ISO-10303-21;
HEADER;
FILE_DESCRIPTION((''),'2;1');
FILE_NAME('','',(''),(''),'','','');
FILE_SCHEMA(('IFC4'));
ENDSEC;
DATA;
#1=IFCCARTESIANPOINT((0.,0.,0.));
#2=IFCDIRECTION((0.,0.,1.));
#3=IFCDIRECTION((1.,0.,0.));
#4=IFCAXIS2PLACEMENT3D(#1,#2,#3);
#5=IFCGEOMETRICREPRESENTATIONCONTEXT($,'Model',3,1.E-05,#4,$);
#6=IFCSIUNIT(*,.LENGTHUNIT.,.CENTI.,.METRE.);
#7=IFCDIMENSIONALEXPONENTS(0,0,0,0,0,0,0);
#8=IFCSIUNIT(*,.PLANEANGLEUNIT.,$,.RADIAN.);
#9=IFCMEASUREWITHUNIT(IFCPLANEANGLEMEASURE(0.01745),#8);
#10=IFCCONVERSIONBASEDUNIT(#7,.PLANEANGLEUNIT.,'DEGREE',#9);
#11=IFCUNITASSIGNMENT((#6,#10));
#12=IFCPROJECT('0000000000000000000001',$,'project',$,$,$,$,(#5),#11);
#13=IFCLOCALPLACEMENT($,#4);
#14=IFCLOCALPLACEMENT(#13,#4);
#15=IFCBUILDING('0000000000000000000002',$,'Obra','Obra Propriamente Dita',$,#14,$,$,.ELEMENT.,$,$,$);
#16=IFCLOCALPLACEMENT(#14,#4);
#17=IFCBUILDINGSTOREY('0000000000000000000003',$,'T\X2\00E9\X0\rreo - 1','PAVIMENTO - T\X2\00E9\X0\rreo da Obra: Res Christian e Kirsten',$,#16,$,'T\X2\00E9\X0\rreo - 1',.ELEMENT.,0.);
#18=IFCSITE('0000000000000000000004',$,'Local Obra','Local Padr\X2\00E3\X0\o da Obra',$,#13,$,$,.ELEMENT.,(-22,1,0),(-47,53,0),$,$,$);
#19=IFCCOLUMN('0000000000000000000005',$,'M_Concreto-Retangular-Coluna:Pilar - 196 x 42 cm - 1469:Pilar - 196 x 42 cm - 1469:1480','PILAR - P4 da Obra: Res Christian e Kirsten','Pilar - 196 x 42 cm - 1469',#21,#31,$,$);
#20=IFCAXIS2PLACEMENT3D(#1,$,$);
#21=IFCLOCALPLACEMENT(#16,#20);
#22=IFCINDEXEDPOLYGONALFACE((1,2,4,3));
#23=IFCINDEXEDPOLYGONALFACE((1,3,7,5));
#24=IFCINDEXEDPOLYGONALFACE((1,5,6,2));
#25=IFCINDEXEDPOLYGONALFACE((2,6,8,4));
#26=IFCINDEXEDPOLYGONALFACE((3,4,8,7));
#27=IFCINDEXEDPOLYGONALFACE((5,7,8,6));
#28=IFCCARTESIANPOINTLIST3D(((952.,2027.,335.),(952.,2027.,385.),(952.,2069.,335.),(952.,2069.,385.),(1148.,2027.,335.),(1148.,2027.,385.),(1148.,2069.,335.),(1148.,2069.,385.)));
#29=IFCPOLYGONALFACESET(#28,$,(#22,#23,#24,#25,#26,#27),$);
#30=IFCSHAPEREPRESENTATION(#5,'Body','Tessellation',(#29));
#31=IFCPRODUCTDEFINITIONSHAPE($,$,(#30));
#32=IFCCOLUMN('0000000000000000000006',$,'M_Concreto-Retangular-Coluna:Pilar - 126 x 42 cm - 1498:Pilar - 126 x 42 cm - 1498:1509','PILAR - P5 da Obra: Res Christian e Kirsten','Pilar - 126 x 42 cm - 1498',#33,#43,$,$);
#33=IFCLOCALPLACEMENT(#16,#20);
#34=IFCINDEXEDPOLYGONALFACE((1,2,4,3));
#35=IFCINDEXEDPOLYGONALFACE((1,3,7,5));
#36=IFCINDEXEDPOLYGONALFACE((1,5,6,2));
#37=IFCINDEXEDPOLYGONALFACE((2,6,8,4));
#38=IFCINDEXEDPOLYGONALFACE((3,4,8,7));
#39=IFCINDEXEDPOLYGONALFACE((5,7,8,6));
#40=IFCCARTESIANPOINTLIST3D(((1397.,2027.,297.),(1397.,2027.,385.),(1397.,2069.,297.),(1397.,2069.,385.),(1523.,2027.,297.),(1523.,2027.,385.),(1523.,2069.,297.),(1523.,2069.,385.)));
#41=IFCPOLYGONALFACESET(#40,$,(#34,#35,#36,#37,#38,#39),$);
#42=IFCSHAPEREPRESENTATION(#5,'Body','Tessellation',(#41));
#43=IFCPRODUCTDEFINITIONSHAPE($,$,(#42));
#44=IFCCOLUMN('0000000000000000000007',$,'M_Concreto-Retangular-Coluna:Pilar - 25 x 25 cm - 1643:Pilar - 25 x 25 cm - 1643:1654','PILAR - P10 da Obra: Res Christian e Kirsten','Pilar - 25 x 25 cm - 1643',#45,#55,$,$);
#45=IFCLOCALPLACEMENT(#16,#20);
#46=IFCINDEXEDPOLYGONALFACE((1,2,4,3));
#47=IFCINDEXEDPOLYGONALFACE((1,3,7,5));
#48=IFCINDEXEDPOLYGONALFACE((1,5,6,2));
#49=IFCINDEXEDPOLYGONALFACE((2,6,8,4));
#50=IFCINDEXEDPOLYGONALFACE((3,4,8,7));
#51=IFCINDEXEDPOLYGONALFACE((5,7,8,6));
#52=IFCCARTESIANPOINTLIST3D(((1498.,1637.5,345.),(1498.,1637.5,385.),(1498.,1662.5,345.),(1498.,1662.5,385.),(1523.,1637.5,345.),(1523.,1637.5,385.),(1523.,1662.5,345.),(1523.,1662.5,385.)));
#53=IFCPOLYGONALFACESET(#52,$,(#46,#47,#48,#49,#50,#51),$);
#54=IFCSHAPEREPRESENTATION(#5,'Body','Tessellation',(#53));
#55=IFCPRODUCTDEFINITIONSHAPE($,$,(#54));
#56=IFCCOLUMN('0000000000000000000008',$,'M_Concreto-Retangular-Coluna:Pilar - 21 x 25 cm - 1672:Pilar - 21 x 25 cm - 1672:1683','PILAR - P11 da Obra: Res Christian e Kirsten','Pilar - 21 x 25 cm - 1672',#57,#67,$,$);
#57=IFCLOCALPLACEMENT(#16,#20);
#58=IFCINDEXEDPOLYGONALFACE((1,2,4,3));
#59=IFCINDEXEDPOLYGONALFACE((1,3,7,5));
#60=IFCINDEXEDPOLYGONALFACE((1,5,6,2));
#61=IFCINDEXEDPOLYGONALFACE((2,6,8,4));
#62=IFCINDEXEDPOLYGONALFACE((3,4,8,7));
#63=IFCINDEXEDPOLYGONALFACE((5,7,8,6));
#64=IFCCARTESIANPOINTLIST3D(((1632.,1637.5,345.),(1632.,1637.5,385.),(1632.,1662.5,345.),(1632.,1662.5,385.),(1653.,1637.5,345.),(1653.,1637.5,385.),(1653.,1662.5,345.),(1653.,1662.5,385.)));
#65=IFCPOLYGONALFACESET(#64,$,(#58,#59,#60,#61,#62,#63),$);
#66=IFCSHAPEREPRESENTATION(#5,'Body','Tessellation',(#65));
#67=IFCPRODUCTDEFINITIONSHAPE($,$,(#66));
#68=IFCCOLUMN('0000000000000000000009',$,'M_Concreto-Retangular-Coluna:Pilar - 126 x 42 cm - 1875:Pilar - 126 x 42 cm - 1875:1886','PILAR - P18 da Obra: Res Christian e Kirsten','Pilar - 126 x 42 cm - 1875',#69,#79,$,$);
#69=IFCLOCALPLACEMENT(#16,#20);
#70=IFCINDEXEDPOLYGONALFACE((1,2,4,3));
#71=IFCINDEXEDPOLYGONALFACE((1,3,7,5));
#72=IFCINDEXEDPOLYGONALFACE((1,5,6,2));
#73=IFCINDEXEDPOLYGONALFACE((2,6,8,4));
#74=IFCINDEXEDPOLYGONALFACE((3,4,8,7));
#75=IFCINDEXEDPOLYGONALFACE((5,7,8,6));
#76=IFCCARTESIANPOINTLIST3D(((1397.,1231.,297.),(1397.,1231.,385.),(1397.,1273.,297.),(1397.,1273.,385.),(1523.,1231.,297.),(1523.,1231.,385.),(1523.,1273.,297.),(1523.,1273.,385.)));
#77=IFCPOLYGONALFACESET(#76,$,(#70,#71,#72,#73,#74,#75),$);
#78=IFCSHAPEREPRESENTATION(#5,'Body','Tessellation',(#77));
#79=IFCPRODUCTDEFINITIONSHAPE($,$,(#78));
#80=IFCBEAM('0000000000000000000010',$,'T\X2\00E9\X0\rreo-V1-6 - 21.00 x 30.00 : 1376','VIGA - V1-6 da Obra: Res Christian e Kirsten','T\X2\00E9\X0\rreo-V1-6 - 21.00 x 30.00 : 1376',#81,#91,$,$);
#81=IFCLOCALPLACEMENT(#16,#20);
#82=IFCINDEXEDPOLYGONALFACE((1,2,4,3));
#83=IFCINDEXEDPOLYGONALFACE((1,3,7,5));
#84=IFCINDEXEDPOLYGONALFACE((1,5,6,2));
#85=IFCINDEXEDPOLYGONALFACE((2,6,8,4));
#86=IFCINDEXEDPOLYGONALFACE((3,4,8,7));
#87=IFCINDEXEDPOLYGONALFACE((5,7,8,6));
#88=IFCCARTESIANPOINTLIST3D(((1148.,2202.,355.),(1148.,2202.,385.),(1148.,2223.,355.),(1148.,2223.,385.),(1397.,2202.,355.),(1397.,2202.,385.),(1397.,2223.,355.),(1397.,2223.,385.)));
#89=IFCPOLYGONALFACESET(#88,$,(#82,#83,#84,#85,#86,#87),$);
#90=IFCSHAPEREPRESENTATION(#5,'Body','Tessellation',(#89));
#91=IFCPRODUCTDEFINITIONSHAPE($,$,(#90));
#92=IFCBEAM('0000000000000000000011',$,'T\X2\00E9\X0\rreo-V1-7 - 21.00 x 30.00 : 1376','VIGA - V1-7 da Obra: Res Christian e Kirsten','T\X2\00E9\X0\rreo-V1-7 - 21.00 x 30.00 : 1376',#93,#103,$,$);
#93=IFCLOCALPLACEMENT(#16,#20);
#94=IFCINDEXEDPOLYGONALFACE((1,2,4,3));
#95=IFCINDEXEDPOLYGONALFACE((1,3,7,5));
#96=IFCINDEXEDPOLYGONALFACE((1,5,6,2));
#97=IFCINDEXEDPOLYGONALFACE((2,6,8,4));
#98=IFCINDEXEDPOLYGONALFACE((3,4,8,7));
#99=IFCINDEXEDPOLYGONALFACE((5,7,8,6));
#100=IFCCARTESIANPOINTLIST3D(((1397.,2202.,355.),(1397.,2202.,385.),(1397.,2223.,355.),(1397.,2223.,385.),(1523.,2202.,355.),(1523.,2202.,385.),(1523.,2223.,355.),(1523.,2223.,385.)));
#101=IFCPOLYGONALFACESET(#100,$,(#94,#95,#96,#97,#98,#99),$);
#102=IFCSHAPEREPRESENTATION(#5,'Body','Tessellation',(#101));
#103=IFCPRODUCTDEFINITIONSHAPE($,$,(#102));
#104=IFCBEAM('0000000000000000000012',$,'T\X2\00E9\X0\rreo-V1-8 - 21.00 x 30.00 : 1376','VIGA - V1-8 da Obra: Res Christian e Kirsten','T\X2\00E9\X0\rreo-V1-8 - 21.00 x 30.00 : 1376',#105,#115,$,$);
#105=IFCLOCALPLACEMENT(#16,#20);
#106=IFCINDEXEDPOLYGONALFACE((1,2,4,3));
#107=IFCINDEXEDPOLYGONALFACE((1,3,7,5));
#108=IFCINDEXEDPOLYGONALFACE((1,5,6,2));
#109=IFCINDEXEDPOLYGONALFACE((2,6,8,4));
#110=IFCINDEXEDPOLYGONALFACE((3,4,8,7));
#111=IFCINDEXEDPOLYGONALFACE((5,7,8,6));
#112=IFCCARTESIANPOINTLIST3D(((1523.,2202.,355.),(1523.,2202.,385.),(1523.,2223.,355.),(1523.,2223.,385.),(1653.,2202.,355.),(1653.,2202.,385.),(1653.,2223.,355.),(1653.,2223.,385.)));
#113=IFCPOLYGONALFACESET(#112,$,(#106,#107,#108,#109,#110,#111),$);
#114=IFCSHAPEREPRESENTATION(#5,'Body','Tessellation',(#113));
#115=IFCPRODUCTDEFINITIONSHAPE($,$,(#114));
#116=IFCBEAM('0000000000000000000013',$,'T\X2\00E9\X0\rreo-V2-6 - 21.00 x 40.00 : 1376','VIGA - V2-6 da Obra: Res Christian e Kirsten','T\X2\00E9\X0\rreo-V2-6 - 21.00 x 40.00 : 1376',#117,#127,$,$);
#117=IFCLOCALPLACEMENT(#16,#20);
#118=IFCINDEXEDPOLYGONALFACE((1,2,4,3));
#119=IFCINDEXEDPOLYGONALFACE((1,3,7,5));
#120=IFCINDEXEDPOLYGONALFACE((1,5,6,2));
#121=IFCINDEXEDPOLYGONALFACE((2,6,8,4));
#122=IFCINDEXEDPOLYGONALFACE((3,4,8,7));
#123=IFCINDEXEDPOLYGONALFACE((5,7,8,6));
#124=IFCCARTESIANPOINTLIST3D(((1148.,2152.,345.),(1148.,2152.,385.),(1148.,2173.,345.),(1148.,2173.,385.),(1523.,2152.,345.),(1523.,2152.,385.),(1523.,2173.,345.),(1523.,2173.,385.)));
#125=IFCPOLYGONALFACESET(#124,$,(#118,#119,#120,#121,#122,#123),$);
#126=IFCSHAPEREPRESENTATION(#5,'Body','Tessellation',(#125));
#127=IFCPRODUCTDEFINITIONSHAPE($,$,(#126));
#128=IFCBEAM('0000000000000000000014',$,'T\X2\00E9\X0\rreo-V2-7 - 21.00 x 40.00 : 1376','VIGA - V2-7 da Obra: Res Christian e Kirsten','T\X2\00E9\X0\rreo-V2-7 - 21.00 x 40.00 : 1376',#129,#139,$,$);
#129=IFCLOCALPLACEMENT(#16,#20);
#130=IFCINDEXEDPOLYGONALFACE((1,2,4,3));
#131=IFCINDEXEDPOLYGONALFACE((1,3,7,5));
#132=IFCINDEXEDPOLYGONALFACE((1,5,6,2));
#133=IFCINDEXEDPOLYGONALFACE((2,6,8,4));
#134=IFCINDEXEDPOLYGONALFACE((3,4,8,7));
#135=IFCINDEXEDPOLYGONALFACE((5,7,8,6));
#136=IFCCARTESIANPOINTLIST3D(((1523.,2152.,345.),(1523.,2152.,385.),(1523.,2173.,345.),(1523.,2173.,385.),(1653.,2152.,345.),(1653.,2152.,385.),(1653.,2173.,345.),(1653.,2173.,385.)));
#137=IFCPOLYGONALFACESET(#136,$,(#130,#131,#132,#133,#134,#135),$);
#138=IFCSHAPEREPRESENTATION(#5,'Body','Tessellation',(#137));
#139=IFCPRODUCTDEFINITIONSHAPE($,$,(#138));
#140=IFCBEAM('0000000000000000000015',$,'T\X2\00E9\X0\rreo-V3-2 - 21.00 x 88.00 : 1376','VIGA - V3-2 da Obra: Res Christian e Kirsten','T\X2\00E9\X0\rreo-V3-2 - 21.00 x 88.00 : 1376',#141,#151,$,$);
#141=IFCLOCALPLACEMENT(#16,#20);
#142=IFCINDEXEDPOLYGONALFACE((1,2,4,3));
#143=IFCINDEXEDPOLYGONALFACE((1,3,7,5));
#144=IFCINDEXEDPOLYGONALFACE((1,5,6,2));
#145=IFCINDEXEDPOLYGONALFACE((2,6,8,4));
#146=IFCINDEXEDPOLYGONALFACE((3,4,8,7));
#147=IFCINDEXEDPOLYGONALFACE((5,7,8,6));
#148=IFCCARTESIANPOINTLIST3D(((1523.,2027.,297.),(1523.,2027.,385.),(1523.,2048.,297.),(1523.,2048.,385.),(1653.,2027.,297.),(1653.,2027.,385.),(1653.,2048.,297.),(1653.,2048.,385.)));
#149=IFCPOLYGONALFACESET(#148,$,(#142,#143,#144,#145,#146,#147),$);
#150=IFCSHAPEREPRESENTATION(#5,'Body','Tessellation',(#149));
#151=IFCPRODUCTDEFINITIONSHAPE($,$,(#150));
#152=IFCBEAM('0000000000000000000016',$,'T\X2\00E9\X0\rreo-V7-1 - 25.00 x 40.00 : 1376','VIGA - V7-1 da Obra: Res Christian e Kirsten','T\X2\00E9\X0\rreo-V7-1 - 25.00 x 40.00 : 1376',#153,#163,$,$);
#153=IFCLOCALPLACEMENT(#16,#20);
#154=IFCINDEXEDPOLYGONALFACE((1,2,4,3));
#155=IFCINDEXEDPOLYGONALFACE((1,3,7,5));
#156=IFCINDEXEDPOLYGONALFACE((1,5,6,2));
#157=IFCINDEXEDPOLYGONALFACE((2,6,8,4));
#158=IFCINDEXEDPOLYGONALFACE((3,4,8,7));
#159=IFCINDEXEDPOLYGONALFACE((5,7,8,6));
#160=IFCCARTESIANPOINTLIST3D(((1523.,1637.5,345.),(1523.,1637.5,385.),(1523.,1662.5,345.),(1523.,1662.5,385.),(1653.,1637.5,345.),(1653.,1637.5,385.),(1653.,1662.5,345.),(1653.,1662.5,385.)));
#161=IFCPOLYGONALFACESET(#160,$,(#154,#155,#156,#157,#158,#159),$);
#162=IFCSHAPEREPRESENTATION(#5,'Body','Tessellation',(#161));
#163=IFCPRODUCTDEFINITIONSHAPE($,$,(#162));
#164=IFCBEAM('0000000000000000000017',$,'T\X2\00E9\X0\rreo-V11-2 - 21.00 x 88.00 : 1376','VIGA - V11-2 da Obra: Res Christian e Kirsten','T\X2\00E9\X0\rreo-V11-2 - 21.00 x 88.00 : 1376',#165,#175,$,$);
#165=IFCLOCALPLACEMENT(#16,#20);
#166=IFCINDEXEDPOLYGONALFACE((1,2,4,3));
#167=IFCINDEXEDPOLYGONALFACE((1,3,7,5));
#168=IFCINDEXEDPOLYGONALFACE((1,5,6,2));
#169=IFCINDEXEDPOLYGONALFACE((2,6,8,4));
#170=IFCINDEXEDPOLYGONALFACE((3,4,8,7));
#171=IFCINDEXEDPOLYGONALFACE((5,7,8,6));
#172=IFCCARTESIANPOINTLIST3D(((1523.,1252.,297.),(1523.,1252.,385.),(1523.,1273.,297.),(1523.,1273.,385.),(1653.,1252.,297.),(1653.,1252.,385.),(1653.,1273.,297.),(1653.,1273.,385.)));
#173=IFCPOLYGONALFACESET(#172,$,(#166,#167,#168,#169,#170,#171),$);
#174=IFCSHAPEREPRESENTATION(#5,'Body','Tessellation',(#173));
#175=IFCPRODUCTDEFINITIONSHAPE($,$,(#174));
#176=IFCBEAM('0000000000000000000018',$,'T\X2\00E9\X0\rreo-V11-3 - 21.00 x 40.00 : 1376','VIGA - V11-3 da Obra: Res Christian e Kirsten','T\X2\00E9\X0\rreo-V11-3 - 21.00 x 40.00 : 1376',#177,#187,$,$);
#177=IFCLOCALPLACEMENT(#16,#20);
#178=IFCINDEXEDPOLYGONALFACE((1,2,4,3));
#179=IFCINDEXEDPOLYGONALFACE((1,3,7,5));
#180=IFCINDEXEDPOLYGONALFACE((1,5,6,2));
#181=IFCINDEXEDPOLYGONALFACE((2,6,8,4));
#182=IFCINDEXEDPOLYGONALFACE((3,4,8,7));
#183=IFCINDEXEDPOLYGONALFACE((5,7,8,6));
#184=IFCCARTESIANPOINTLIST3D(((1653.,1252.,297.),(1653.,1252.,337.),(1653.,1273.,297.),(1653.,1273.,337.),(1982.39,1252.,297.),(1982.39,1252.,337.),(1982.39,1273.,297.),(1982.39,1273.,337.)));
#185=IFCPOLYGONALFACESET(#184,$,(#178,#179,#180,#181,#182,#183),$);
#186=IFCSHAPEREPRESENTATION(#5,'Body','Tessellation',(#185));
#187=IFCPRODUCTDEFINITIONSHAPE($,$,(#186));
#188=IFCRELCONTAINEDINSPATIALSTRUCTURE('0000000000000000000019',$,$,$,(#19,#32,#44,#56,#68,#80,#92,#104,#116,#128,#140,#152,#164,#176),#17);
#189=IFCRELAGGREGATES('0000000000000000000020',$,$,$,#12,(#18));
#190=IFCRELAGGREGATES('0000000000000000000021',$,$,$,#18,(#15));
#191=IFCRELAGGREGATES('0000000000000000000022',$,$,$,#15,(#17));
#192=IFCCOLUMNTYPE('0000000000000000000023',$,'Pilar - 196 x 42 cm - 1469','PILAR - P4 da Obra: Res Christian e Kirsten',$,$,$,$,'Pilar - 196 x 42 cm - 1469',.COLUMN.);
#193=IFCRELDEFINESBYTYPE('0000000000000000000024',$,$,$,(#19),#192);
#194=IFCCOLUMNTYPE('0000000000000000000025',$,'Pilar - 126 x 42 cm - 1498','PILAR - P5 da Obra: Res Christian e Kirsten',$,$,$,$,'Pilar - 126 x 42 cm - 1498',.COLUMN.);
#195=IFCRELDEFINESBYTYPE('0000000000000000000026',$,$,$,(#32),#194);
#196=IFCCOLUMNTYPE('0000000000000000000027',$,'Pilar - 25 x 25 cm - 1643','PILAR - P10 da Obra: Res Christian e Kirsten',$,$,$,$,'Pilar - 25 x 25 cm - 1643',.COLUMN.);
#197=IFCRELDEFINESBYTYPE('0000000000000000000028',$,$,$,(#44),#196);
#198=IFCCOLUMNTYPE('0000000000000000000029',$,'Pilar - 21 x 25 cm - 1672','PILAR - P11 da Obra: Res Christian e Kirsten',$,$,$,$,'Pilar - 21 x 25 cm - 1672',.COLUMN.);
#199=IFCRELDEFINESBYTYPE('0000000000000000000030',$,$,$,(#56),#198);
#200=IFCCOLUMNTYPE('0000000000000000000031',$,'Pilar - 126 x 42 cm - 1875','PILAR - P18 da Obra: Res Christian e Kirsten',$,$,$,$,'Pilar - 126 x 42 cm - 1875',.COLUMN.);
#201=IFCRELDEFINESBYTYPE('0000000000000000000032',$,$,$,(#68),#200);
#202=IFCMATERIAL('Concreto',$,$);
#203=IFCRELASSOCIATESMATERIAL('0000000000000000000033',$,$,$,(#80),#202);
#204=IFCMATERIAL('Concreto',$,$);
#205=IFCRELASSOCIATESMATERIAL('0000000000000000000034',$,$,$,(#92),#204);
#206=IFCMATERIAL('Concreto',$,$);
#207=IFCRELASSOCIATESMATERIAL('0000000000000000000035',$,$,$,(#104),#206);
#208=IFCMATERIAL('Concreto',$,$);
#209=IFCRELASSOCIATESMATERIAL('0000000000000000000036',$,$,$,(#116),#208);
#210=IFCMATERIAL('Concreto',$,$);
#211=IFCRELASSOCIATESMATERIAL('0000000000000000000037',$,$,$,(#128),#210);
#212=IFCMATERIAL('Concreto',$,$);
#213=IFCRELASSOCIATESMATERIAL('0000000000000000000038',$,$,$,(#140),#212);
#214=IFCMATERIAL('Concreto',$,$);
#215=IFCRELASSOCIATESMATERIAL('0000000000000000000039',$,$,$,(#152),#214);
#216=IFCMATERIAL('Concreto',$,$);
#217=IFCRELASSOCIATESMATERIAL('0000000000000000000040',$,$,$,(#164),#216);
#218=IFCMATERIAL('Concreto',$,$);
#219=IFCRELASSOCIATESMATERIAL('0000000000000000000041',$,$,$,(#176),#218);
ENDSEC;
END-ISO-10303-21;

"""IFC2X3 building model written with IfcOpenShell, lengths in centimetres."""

from ifc_helpers import new_model, entity, si_unit, converted_unit, frame, origin, origin_with_axes, origin_2d_with_axis, place, context, project, spatial, polyline, rectangle, outline, extrude, source, transform, mapped, material, type_object, type_shapes, element, save


model = new_model("IFC2X3")

# Units and contexts
model_context = context("Model", 3, precision=1e-05, world=origin_with_axes())
ifc_project = project(units=[si_unit("LENGTHUNIT", "METRE", prefix="CENTI"), converted_unit("PLANEANGLEUNIT", "DEGREE", entity("IfcPlaneAngleMeasure", 0.01745), si_unit("PLANEANGLEUNIT", "RADIAN"), dimensions=[0, 0, 0, 0, 0, 0, 0])], contexts=[model_context])

# Site, building, storey
site_placement = place(None, origin_with_axes())
site = spatial("IfcSite", under=ifc_project, at=site_placement, Name="Local Obra", Description="Local Padrão da Obra", CompositionType="ELEMENT", RefLatitude=(-22, 1, 0), RefLongitude=(-47, 53, 0))
building_placement = place(site_placement, origin_with_axes())
building = spatial("IfcBuilding", under=site, at=building_placement, Name="Obra", Description="Obra Propriamente Dita", CompositionType="ELEMENT")
storey_placement = place(building_placement, origin_with_axes())
storey = spatial("IfcBuildingStorey", under=building, at=storey_placement, Name="Térreo - 1", Description="PAVIMENTO - Térreo da Obra: Res Christian e Kirsten", LongName="Térreo - 1", CompositionType="ELEMENT", Elevation=0.0)

# Columns
column_type_1 = type_object("IfcColumnType", Name="Pilar - 196 x 42 cm - 1469", Description="PILAR - P4 da Obra: Res Christian e Kirsten", ElementType="Pilar - 196 x 42 cm - 1469", PredefinedType="COLUMN")
shared_shape_1 = source(origin(), model_context, "Body", "SweptSolid", [
    extrude(rectangle(XDim=196.0, YDim=42.0, at=origin_2d_with_axis()), origin(), (0.0, 0.0, 1.0), 50.0),
])
type_shapes(column_type_1, [shared_shape_1])
column_1_placement = place(storey_placement, frame((1050.0, 2048.0, 335.0), z_axis=(0.0, 0.0, 1.0), x_axis=(1.0, 0.0, 0.0)))
element("IfcColumn", 1, at=column_1_placement, inside=storey, type_object=column_type_1, Name="M_Concreto-Retangular-Coluna:Pilar - 196 x 42 cm - 1469:Pilar - 196 x 42 cm - 1469:1480", Description="PILAR - P4 da Obra: Res Christian e Kirsten", ObjectType="Pilar - 196 x 42 cm - 1469", context=model_context, shape_type="MappedRepresentation", body=[
    mapped(shared_shape_1, transform((0.0, 0.0, 0.0), scale=1.0)),
])
column_type_2 = type_object("IfcColumnType", Name="Pilar - 126 x 42 cm - 1498", Description="PILAR - P5 da Obra: Res Christian e Kirsten", ElementType="Pilar - 126 x 42 cm - 1498", PredefinedType="COLUMN")
shared_shape_2 = source(origin(), model_context, "Body", "SweptSolid", [
    extrude(rectangle(XDim=126.0, YDim=42.0, at=origin_2d_with_axis()), origin(), (0.0, 0.0, 1.0), 88.0),
])
type_shapes(column_type_2, [shared_shape_2])
column_2_placement = place(storey_placement, frame((1460.0, 2048.0, 297.0), z_axis=(0.0, 0.0, 1.0), x_axis=(1.0, 0.0, 0.0)))
element("IfcColumn", 2, at=column_2_placement, inside=storey, type_object=column_type_2, Name="M_Concreto-Retangular-Coluna:Pilar - 126 x 42 cm - 1498:Pilar - 126 x 42 cm - 1498:1509", Description="PILAR - P5 da Obra: Res Christian e Kirsten", ObjectType="Pilar - 126 x 42 cm - 1498", context=model_context, shape_type="MappedRepresentation", body=[
    mapped(shared_shape_2, transform((0.0, 0.0, 0.0), scale=1.0)),
])
column_type_3 = type_object("IfcColumnType", Name="Pilar - 25 x 25 cm - 1643", Description="PILAR - P10 da Obra: Res Christian e Kirsten", ElementType="Pilar - 25 x 25 cm - 1643", PredefinedType="COLUMN")
shared_shape_3 = source(origin(), model_context, "Body", "SweptSolid", [
    extrude(rectangle(XDim=25.0, YDim=25.0, at=origin_2d_with_axis()), origin(), (0.0, 0.0, 1.0), 40.0),
])
type_shapes(column_type_3, [shared_shape_3])
column_3_placement = place(storey_placement, frame((1510.5, 1650.0, 345.0), z_axis=(0.0, 0.0, 1.0), x_axis=(1.0, 0.0, 0.0)))
element("IfcColumn", 3, at=column_3_placement, inside=storey, type_object=column_type_3, Name="M_Concreto-Retangular-Coluna:Pilar - 25 x 25 cm - 1643:Pilar - 25 x 25 cm - 1643:1654", Description="PILAR - P10 da Obra: Res Christian e Kirsten", ObjectType="Pilar - 25 x 25 cm - 1643", context=model_context, shape_type="MappedRepresentation", body=[
    mapped(shared_shape_3, transform((0.0, 0.0, 0.0), scale=1.0)),
])
column_type_4 = type_object("IfcColumnType", Name="Pilar - 21 x 25 cm - 1672", Description="PILAR - P11 da Obra: Res Christian e Kirsten", ElementType="Pilar - 21 x 25 cm - 1672", PredefinedType="COLUMN")
shared_shape_4 = source(origin(), model_context, "Body", "SweptSolid", [
    extrude(rectangle(XDim=21.0, YDim=25.0, at=origin_2d_with_axis()), origin(), (0.0, 0.0, 1.0), 40.0),
])
type_shapes(column_type_4, [shared_shape_4])
column_4_placement = place(storey_placement, frame((1642.5, 1650.0, 345.0), z_axis=(0.0, 0.0, 1.0), x_axis=(1.0, 0.0, 0.0)))
element("IfcColumn", 4, at=column_4_placement, inside=storey, type_object=column_type_4, Name="M_Concreto-Retangular-Coluna:Pilar - 21 x 25 cm - 1672:Pilar - 21 x 25 cm - 1672:1683", Description="PILAR - P11 da Obra: Res Christian e Kirsten", ObjectType="Pilar - 21 x 25 cm - 1672", context=model_context, shape_type="MappedRepresentation", body=[
    mapped(shared_shape_4, transform((0.0, 0.0, 0.0), scale=1.0)),
])
column_type_5 = type_object("IfcColumnType", Name="Pilar - 126 x 42 cm - 1875", Description="PILAR - P18 da Obra: Res Christian e Kirsten", ElementType="Pilar - 126 x 42 cm - 1875", PredefinedType="COLUMN")
shared_shape_5 = source(origin(), model_context, "Body", "SweptSolid", [
    extrude(rectangle(XDim=126.0, YDim=42.0, at=origin_2d_with_axis()), origin(), (0.0, 0.0, 1.0), 88.0),
])
type_shapes(column_type_5, [shared_shape_5])
column_5_placement = place(storey_placement, frame((1460.0, 1252.0, 297.0), z_axis=(0.0, 0.0, 1.0), x_axis=(1.0, 0.0, 0.0)))
element("IfcColumn", 5, at=column_5_placement, inside=storey, type_object=column_type_5, Name="M_Concreto-Retangular-Coluna:Pilar - 126 x 42 cm - 1875:Pilar - 126 x 42 cm - 1875:1886", Description="PILAR - P18 da Obra: Res Christian e Kirsten", ObjectType="Pilar - 126 x 42 cm - 1875", context=model_context, shape_type="MappedRepresentation", body=[
    mapped(shared_shape_5, transform((0.0, 0.0, 0.0), scale=1.0)),
])

# Beams
ifc_material_1 = material(Name="Concreto")
beam_1_placement = place(storey_placement, frame((1148.0, 2223.0, 385.0), z_axis=(1.0, 0.0, 0.0), x_axis=(0.0, -1.0, 0.0)))
element("IfcBeam", 6, at=beam_1_placement, inside=storey, material=ifc_material_1, Name="Térreo-V1-6 - 21.00 x 30.00 : 1376", Description="VIGA - V1-6 da Obra: Res Christian e Kirsten", ObjectType="Térreo-V1-6 - 21.00 x 30.00 : 1376", context=model_context, shape_type="SweptSolid", body=[
    extrude(outline(polyline([(0.0, 0.0), (21.0, 0.0), (21.0, 30.0), (0.0, 30.0), (0.0, 0.0)])), origin_with_axes(), (0.0, 0.0, 1.0), 249.0),
])
ifc_material_2 = material(Name="Concreto")
beam_2_placement = place(storey_placement, frame((1397.0, 2223.0, 385.0), z_axis=(1.0, 0.0, 0.0), x_axis=(0.0, -1.0, 0.0)))
element("IfcBeam", 7, at=beam_2_placement, inside=storey, material=ifc_material_2, Name="Térreo-V1-7 - 21.00 x 30.00 : 1376", Description="VIGA - V1-7 da Obra: Res Christian e Kirsten", ObjectType="Térreo-V1-7 - 21.00 x 30.00 : 1376", context=model_context, shape_type="SweptSolid", body=[
    extrude(outline(polyline([(0.0, 0.0), (21.0, 0.0), (21.0, 30.0), (0.0, 30.0), (0.0, 0.0)])), origin_with_axes(), (0.0, 0.0, 1.0), 126.0),
])
ifc_material_3 = material(Name="Concreto")
beam_3_placement = place(storey_placement, frame((1523.0, 2223.0, 385.0), z_axis=(1.0, 0.0, 0.0), x_axis=(0.0, -1.0, 0.0)))
element("IfcBeam", 8, at=beam_3_placement, inside=storey, material=ifc_material_3, Name="Térreo-V1-8 - 21.00 x 30.00 : 1376", Description="VIGA - V1-8 da Obra: Res Christian e Kirsten", ObjectType="Térreo-V1-8 - 21.00 x 30.00 : 1376", context=model_context, shape_type="SweptSolid", body=[
    extrude(outline(polyline([(0.0, 0.0), (21.0, 0.0), (21.0, 30.0), (0.0, 30.0), (0.0, 0.0)])), origin_with_axes(), (0.0, 0.0, 1.0), 130.0),
])
ifc_material_4 = material(Name="Concreto")
beam_4_placement = place(storey_placement, frame((1148.0, 2173.0, 385.0), z_axis=(1.0, 0.0, 0.0), x_axis=(0.0, -1.0, 0.0)))
element("IfcBeam", 9, at=beam_4_placement, inside=storey, material=ifc_material_4, Name="Térreo-V2-6 - 21.00 x 40.00 : 1376", Description="VIGA - V2-6 da Obra: Res Christian e Kirsten", ObjectType="Térreo-V2-6 - 21.00 x 40.00 : 1376", context=model_context, shape_type="SweptSolid", body=[
    extrude(outline(polyline([(0.0, 0.0), (21.0, 0.0), (21.0, 40.0), (0.0, 40.0), (0.0, 0.0)])), origin_with_axes(), (0.0, 0.0, 1.0), 375.0),
])
ifc_material_5 = material(Name="Concreto")
beam_5_placement = place(storey_placement, frame((1523.0, 2173.0, 385.0), z_axis=(1.0, 0.0, 0.0), x_axis=(0.0, -1.0, 0.0)))
element("IfcBeam", 10, at=beam_5_placement, inside=storey, material=ifc_material_5, Name="Térreo-V2-7 - 21.00 x 40.00 : 1376", Description="VIGA - V2-7 da Obra: Res Christian e Kirsten", ObjectType="Térreo-V2-7 - 21.00 x 40.00 : 1376", context=model_context, shape_type="SweptSolid", body=[
    extrude(outline(polyline([(0.0, 0.0), (21.0, 0.0), (21.0, 40.0), (0.0, 40.0), (0.0, 0.0)])), origin_with_axes(), (0.0, 0.0, 1.0), 130.0),
])
ifc_material_6 = material(Name="Concreto")
beam_6_placement = place(storey_placement, frame((1523.0, 2048.0, 385.0), z_axis=(1.0, 0.0, 0.0), x_axis=(0.0, -1.0, 0.0)))
element("IfcBeam", 11, at=beam_6_placement, inside=storey, material=ifc_material_6, Name="Térreo-V3-2 - 21.00 x 88.00 : 1376", Description="VIGA - V3-2 da Obra: Res Christian e Kirsten", ObjectType="Térreo-V3-2 - 21.00 x 88.00 : 1376", context=model_context, shape_type="SweptSolid", body=[
    extrude(outline(polyline([(0.0, 0.0), (21.0, 0.0), (21.0, 88.0), (0.0, 88.0), (0.0, 0.0)])), origin_with_axes(), (0.0, 0.0, 1.0), 130.0),
])
ifc_material_7 = material(Name="Concreto")
beam_7_placement = place(storey_placement, frame((1523.0, 1650.0, 385.0), z_axis=(1.0, 0.0, 0.0), x_axis=(0.0, -1.0, 0.0)))
element("IfcBeam", 12, at=beam_7_placement, inside=storey, material=ifc_material_7, Name="Térreo-V7-1 - 25.00 x 40.00 : 1376", Description="VIGA - V7-1 da Obra: Res Christian e Kirsten", ObjectType="Térreo-V7-1 - 25.00 x 40.00 : 1376", context=model_context, shape_type="SweptSolid", body=[
    extrude(outline(polyline([(-12.5, 0.0), (12.5, 0.0), (12.5, 40.0), (-12.5, 40.0), (-12.5, 0.0)])), origin_with_axes(), (0.0, 0.0, 1.0), 130.0),
])
ifc_material_8 = material(Name="Concreto")
beam_8_placement = place(storey_placement, frame((1523.0, 1252.0, 385.0), z_axis=(1.0, 0.0, 0.0), x_axis=(0.0, -1.0, 0.0)))
element("IfcBeam", 13, at=beam_8_placement, inside=storey, material=ifc_material_8, Name="Térreo-V11-2 - 21.00 x 88.00 : 1376", Description="VIGA - V11-2 da Obra: Res Christian e Kirsten", ObjectType="Térreo-V11-2 - 21.00 x 88.00 : 1376", context=model_context, shape_type="SweptSolid", body=[
    extrude(outline(polyline([(-21.0, 0.0), (0.0, 0.0), (0.0, 88.0), (-21.0, 88.0), (-21.0, 0.0)])), origin_with_axes(), (0.0, 0.0, 1.0), 130.0),
])
ifc_material_9 = material(Name="Concreto")
beam_9_placement = place(storey_placement, frame((1653.0, 1252.0, 337.0), z_axis=(1.0, 0.0, 0.0), x_axis=(0.0, -1.0, 0.0)))
element("IfcBeam", 14, at=beam_9_placement, inside=storey, material=ifc_material_9, Name="Térreo-V11-3 - 21.00 x 40.00 : 1376", Description="VIGA - V11-3 da Obra: Res Christian e Kirsten", ObjectType="Térreo-V11-3 - 21.00 x 40.00 : 1376", context=model_context, shape_type="SweptSolid", body=[
    extrude(outline(polyline([(-21.0, 0.0), (0.0, 0.0), (0.0, 40.0), (-21.0, 40.0), (-21.0, 0.0)])), origin_with_axes(), (0.0, 0.0, 1.0), 329.39),
])

save(model, "model.ifc")
